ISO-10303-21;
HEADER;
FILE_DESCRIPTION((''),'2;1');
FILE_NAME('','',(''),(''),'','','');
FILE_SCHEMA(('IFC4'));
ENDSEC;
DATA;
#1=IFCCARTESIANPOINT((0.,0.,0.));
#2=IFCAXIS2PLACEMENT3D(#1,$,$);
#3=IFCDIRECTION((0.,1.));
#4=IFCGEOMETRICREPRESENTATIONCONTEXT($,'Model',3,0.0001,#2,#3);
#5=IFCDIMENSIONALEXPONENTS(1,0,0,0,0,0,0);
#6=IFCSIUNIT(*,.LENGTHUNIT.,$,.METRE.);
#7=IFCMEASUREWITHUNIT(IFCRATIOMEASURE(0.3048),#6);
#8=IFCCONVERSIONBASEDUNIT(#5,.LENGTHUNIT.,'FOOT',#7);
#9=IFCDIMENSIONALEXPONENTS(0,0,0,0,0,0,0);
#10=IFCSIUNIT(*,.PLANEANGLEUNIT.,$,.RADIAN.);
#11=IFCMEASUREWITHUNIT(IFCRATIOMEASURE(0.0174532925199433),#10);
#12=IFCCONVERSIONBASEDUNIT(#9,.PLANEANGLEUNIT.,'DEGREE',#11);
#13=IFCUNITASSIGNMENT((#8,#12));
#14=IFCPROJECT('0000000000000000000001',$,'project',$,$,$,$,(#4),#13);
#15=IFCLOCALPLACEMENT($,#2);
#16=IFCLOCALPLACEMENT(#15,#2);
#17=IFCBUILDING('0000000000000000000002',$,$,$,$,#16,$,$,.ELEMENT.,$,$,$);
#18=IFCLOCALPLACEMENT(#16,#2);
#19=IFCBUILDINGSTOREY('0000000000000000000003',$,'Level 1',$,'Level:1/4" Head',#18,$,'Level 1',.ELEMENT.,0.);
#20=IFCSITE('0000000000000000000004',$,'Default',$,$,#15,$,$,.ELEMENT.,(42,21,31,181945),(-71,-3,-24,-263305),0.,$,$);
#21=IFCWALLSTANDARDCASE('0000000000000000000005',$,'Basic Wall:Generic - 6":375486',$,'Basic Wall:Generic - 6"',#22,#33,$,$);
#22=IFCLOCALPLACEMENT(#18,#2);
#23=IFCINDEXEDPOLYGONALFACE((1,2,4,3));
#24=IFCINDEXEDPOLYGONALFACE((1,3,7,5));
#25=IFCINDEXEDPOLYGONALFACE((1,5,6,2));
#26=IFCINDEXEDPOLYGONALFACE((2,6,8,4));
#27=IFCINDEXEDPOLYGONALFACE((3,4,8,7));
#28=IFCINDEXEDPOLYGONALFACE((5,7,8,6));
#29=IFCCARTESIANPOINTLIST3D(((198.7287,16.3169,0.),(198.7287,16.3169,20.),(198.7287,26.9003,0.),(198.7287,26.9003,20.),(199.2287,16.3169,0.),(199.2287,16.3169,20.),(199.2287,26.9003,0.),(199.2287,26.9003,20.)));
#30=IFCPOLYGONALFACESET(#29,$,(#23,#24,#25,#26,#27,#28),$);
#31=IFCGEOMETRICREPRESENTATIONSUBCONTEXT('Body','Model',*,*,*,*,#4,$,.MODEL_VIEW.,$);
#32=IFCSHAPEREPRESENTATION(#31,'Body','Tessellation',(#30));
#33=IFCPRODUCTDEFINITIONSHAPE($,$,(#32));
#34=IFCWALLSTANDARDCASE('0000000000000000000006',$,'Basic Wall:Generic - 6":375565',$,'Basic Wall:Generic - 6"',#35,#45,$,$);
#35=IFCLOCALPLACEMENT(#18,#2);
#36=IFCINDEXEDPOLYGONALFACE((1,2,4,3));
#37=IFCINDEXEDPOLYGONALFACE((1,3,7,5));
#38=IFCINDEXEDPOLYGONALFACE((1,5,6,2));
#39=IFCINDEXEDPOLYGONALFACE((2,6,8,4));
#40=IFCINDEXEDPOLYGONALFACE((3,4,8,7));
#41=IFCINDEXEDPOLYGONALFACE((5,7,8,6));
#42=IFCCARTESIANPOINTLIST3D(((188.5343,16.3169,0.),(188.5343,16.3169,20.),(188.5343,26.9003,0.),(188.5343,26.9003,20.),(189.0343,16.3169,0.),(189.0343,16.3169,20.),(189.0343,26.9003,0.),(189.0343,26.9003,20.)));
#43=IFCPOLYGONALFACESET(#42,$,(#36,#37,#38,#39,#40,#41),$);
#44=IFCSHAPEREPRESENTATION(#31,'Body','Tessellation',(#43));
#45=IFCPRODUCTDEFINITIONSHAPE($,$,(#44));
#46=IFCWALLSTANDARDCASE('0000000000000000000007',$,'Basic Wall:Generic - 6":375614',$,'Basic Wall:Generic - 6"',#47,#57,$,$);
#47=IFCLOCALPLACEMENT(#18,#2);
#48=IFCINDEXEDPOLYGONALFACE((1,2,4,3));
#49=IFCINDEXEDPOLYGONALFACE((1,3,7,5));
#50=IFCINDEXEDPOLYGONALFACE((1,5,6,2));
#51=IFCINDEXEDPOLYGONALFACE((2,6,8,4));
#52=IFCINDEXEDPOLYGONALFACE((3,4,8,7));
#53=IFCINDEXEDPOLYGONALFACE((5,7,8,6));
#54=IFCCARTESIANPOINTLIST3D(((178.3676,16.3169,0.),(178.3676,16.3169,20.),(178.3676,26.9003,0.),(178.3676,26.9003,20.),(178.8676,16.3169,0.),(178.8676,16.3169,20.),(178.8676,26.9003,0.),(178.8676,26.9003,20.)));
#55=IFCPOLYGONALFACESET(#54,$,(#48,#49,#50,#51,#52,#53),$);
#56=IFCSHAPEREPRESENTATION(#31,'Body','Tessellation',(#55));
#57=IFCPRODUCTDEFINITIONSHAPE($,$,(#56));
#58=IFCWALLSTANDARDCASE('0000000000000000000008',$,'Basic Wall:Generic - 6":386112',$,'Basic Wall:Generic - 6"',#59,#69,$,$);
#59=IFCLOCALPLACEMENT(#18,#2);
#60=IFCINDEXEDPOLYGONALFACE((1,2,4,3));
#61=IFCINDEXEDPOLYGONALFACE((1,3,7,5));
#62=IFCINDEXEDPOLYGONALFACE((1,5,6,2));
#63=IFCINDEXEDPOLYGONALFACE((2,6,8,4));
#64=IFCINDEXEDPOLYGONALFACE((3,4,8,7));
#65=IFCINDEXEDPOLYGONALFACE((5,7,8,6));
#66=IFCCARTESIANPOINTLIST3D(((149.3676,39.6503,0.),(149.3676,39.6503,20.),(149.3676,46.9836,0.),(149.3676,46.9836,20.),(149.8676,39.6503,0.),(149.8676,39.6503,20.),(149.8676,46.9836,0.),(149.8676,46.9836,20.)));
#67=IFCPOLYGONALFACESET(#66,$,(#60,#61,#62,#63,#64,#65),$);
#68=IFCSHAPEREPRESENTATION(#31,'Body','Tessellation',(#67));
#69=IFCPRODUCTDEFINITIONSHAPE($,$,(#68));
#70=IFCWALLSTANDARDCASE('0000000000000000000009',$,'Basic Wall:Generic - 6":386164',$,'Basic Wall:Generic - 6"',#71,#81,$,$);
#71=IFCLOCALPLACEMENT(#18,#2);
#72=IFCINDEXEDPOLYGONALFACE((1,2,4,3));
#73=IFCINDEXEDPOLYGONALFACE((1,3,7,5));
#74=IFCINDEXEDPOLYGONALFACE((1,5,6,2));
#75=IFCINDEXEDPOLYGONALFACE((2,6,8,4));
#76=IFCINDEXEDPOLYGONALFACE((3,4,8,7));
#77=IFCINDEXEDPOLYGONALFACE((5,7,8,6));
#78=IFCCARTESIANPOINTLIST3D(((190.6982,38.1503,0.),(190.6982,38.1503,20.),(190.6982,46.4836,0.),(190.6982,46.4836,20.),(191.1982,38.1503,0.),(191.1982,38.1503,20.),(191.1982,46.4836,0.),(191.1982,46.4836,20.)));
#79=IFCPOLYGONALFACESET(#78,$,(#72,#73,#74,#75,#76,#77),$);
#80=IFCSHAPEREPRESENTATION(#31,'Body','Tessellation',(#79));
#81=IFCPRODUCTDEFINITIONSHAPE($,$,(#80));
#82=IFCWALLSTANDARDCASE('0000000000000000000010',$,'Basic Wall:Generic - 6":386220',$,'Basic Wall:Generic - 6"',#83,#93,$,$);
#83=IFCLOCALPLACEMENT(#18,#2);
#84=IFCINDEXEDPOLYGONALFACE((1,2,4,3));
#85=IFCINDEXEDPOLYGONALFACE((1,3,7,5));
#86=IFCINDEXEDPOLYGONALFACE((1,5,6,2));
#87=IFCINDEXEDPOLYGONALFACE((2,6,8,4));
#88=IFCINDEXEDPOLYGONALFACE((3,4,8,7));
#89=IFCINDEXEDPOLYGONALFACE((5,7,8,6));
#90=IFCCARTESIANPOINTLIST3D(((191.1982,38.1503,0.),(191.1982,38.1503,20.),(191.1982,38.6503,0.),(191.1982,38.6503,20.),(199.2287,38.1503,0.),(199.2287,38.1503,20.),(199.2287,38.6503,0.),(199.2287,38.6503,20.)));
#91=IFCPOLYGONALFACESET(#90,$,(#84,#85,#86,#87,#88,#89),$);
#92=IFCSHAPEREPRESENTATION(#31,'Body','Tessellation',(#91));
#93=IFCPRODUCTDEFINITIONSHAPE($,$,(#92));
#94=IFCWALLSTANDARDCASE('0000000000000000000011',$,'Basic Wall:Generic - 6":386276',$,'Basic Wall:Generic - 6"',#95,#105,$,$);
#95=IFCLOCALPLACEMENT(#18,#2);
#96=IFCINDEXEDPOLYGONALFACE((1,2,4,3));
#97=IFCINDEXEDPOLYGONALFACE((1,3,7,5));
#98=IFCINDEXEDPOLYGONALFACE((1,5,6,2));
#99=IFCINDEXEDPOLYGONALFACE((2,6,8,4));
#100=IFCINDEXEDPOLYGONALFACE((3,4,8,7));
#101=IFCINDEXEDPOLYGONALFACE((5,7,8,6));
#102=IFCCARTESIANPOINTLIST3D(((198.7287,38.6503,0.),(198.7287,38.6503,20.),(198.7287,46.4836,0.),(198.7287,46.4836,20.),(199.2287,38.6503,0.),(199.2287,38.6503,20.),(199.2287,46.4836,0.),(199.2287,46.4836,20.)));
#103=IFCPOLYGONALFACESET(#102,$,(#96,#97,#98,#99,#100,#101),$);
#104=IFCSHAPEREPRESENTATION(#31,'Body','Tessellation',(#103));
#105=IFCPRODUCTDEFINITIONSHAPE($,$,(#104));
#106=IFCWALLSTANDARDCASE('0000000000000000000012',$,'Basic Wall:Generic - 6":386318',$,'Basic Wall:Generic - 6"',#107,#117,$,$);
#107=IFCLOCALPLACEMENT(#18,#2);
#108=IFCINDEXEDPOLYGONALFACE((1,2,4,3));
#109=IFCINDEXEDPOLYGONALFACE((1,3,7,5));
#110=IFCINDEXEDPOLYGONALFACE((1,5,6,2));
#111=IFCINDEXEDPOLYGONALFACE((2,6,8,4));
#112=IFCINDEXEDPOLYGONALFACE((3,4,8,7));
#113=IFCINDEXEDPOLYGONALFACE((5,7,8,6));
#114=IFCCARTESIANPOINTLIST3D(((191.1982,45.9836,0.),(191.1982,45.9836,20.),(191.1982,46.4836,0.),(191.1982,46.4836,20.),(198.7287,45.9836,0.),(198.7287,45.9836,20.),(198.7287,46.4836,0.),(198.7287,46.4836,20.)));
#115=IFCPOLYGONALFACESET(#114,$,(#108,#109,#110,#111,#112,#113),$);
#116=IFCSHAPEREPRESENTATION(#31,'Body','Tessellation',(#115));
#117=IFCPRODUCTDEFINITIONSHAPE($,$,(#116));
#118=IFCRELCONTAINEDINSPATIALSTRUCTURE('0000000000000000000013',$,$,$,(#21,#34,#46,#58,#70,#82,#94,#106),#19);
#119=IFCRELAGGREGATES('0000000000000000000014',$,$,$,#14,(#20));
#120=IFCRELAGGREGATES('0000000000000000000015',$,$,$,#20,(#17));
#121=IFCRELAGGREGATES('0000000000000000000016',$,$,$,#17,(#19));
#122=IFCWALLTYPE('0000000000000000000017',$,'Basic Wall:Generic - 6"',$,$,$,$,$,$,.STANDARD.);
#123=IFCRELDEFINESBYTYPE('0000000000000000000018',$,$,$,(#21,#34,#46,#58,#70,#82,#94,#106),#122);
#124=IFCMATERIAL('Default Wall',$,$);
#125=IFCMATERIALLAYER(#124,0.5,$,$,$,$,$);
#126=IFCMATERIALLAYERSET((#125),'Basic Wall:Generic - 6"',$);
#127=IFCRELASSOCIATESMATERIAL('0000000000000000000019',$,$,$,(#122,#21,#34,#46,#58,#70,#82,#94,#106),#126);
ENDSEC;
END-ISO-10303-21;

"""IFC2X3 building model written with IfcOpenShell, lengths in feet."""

from ifc_helpers import new_model, entity, si_unit, converted_unit, direction, frame, frame_2d, origin, place, context, subcontext, project, spatial, rectangle, extrude, material, layer, layer_set, layer_usage, type_object, element, save


model = new_model("IFC2X3")

# Units and contexts
model_context = context("Model", 3, precision=0.0001, world=origin(), true_north=direction((0.0, 1.0)))
body_context = subcontext(model_context, "Body", "Model", "MODEL_VIEW")
ifc_project = project(units=[converted_unit("LENGTHUNIT", "FOOT", entity("IfcRatioMeasure", 0.3048), si_unit("LENGTHUNIT", "METRE"), dimensions=[1, 0, 0, 0, 0, 0, 0]), converted_unit("PLANEANGLEUNIT", "DEGREE", entity("IfcRatioMeasure", 0.0174532925199433), si_unit("PLANEANGLEUNIT", "RADIAN"), dimensions=[0, 0, 0, 0, 0, 0, 0])], contexts=[model_context])

# Site, building, storey
site_placement = place(None, origin())
site = spatial("IfcSite", under=ifc_project, at=site_placement, Name="Default", CompositionType="ELEMENT", RefLatitude=(42, 21, 31, 181945), RefLongitude=(-71, -3, -24, -263305), RefElevation=0.0)
building_placement = place(site_placement, origin())
building = spatial("IfcBuilding", under=site, at=building_placement, CompositionType="ELEMENT")
storey_placement = place(building_placement, origin())
storey = spatial("IfcBuildingStorey", under=building, at=storey_placement, Name="Level 1", ObjectType="Level:1/4\" Head", LongName="Level 1", CompositionType="ELEMENT", Elevation=0.0)

# Walls
ifc_material = material(Name="Default Wall")
ifc_layer_1 = layer(ifc_material, 0.5)
ifc_layer_set_1 = layer_set([ifc_layer_1], Name="Basic Wall:Generic - 6\"")
wall_type_1 = type_object("IfcWallType", Name="Basic Wall:Generic - 6\"", PredefinedType="STANDARD", material=ifc_layer_set_1)
ifc_layer_usage_1 = layer_usage(ifc_layer_set_1, "AXIS2", "NEGATIVE", 0.25)
wall_1_placement = place(storey_placement, frame((198.9787, 26.9003, 0.0), z_axis=(0.0, 0.0, 1.0), x_axis=(0.0, -1.0, 0.0)))
element("IfcWallStandardCase", 1, at=wall_1_placement, inside=storey, type_object=wall_type_1, material=ifc_layer_usage_1, Name="Basic Wall:Generic - 6\":375486", ObjectType="Basic Wall:Generic - 6\"", context=body_context, shape_type="SweptSolid", body=[
    extrude(rectangle(XDim=10.5833, YDim=0.5, at=frame_2d((5.2917, 0.0), x_axis=(-1.0, 0.0))), origin(), (0.0, 0.0, 1.0), 20.0),
])
ifc_layer_usage_2 = layer_usage(ifc_layer_set_1, "AXIS2", "NEGATIVE", 0.25)
wall_2_placement = place(storey_placement, frame((188.7843, 26.9003, 0.0), z_axis=(0.0, 0.0, 1.0), x_axis=(0.0, -1.0, 0.0)))
element("IfcWallStandardCase", 2, at=wall_2_placement, inside=storey, type_object=wall_type_1, material=ifc_layer_usage_2, Name="Basic Wall:Generic - 6\":375565", ObjectType="Basic Wall:Generic - 6\"", context=body_context, shape_type="SweptSolid", body=[
    extrude(rectangle(XDim=10.5833, YDim=0.5, at=frame_2d((5.2917, 0.0), x_axis=(-1.0, 0.0))), origin(), (0.0, 0.0, 1.0), 20.0),
])
ifc_layer_usage_3 = layer_usage(ifc_layer_set_1, "AXIS2", "NEGATIVE", 0.25)
wall_3_placement = place(storey_placement, frame((178.6176, 26.9003, 0.0), z_axis=(0.0, 0.0, 1.0), x_axis=(0.0, -1.0, 0.0)))
element("IfcWallStandardCase", 3, at=wall_3_placement, inside=storey, type_object=wall_type_1, material=ifc_layer_usage_3, Name="Basic Wall:Generic - 6\":375614", ObjectType="Basic Wall:Generic - 6\"", context=body_context, shape_type="SweptSolid", body=[
    extrude(rectangle(XDim=10.5833, YDim=0.5, at=frame_2d((5.2917, 0.0), x_axis=(-1.0, 0.0))), origin(), (0.0, 0.0, 1.0), 20.0),
])
ifc_layer_usage_4 = layer_usage(ifc_layer_set_1, "AXIS2", "NEGATIVE", 0.25)
wall_4_placement = place(storey_placement, frame((149.6176, 46.9836, 0.0), z_axis=(0.0, 0.0, 1.0), x_axis=(0.0, -1.0, 0.0)))
element("IfcWallStandardCase", 4, at=wall_4_placement, inside=storey, type_object=wall_type_1, material=ifc_layer_usage_4, Name="Basic Wall:Generic - 6\":386112", ObjectType="Basic Wall:Generic - 6\"", context=body_context, shape_type="SweptSolid", body=[
    extrude(rectangle(XDim=7.3333, YDim=0.5, at=frame_2d((3.6667, 0.0), x_axis=(-1.0, 0.0))), origin(), (0.0, 0.0, 1.0), 20.0),
])
ifc_layer_usage_5 = layer_usage(ifc_layer_set_1, "AXIS2", "NEGATIVE", 0.25)
wall_5_placement = place(storey_placement, frame((190.9482, 46.4836, 0.0), z_axis=(0.0, 0.0, 1.0), x_axis=(0.0, -1.0, 0.0)))
element("IfcWallStandardCase", 5, at=wall_5_placement, inside=storey, type_object=wall_type_1, material=ifc_layer_usage_5, Name="Basic Wall:Generic - 6\":386164", ObjectType="Basic Wall:Generic - 6\"", context=body_context, shape_type="SweptSolid", body=[
    extrude(rectangle(XDim=8.3333, YDim=0.5, at=frame_2d((4.1667, 0.0), x_axis=(-1.0, 0.0))), origin(), (0.0, 0.0, 1.0), 20.0),
])
ifc_layer_usage_6 = layer_usage(ifc_layer_set_1, "AXIS2", "NEGATIVE", 0.25)
wall_6_placement = place(storey_placement, frame((191.1982, 38.4003, 0.0)))
element("IfcWallStandardCase", 6, at=wall_6_placement, inside=storey, type_object=wall_type_1, material=ifc_layer_usage_6, Name="Basic Wall:Generic - 6\":386220", ObjectType="Basic Wall:Generic - 6\"", context=body_context, shape_type="SweptSolid", body=[
    extrude(rectangle(XDim=8.0305, YDim=0.5, at=frame_2d((4.0153, 0.0), x_axis=(-1.0, 0.0))), origin(), (0.0, 0.0, 1.0), 20.0),
])
ifc_layer_usage_7 = layer_usage(ifc_layer_set_1, "AXIS2", "NEGATIVE", 0.25)
wall_7_placement = place(storey_placement, frame((198.9787, 38.6503, 0.0), z_axis=(0.0, 0.0, 1.0), x_axis=(0.0, 1.0, 0.0)))
element("IfcWallStandardCase", 7, at=wall_7_placement, inside=storey, type_object=wall_type_1, material=ifc_layer_usage_7, Name="Basic Wall:Generic - 6\":386276", ObjectType="Basic Wall:Generic - 6\"", context=body_context, shape_type="SweptSolid", body=[
    extrude(rectangle(XDim=7.8333, YDim=0.5, at=frame_2d((3.9167, 0.0), x_axis=(-1.0, 0.0))), origin(), (0.0, 0.0, 1.0), 20.0),
])
ifc_layer_usage_8 = layer_usage(ifc_layer_set_1, "AXIS2", "NEGATIVE", 0.25)
wall_8_placement = place(storey_placement, frame((198.7287, 46.2336, 0.0), z_axis=(0.0, 0.0, 1.0), x_axis=(-1.0, 0.0, 0.0)))
element("IfcWallStandardCase", 8, at=wall_8_placement, inside=storey, type_object=wall_type_1, material=ifc_layer_usage_8, Name="Basic Wall:Generic - 6\":386318", ObjectType="Basic Wall:Generic - 6\"", context=body_context, shape_type="SweptSolid", body=[
    extrude(rectangle(XDim=7.5305, YDim=0.5, at=frame_2d((3.7653, 0.0), x_axis=(-1.0, 0.0))), origin(), (0.0, 0.0, 1.0), 20.0),
])

save(model, "model.ifc")
